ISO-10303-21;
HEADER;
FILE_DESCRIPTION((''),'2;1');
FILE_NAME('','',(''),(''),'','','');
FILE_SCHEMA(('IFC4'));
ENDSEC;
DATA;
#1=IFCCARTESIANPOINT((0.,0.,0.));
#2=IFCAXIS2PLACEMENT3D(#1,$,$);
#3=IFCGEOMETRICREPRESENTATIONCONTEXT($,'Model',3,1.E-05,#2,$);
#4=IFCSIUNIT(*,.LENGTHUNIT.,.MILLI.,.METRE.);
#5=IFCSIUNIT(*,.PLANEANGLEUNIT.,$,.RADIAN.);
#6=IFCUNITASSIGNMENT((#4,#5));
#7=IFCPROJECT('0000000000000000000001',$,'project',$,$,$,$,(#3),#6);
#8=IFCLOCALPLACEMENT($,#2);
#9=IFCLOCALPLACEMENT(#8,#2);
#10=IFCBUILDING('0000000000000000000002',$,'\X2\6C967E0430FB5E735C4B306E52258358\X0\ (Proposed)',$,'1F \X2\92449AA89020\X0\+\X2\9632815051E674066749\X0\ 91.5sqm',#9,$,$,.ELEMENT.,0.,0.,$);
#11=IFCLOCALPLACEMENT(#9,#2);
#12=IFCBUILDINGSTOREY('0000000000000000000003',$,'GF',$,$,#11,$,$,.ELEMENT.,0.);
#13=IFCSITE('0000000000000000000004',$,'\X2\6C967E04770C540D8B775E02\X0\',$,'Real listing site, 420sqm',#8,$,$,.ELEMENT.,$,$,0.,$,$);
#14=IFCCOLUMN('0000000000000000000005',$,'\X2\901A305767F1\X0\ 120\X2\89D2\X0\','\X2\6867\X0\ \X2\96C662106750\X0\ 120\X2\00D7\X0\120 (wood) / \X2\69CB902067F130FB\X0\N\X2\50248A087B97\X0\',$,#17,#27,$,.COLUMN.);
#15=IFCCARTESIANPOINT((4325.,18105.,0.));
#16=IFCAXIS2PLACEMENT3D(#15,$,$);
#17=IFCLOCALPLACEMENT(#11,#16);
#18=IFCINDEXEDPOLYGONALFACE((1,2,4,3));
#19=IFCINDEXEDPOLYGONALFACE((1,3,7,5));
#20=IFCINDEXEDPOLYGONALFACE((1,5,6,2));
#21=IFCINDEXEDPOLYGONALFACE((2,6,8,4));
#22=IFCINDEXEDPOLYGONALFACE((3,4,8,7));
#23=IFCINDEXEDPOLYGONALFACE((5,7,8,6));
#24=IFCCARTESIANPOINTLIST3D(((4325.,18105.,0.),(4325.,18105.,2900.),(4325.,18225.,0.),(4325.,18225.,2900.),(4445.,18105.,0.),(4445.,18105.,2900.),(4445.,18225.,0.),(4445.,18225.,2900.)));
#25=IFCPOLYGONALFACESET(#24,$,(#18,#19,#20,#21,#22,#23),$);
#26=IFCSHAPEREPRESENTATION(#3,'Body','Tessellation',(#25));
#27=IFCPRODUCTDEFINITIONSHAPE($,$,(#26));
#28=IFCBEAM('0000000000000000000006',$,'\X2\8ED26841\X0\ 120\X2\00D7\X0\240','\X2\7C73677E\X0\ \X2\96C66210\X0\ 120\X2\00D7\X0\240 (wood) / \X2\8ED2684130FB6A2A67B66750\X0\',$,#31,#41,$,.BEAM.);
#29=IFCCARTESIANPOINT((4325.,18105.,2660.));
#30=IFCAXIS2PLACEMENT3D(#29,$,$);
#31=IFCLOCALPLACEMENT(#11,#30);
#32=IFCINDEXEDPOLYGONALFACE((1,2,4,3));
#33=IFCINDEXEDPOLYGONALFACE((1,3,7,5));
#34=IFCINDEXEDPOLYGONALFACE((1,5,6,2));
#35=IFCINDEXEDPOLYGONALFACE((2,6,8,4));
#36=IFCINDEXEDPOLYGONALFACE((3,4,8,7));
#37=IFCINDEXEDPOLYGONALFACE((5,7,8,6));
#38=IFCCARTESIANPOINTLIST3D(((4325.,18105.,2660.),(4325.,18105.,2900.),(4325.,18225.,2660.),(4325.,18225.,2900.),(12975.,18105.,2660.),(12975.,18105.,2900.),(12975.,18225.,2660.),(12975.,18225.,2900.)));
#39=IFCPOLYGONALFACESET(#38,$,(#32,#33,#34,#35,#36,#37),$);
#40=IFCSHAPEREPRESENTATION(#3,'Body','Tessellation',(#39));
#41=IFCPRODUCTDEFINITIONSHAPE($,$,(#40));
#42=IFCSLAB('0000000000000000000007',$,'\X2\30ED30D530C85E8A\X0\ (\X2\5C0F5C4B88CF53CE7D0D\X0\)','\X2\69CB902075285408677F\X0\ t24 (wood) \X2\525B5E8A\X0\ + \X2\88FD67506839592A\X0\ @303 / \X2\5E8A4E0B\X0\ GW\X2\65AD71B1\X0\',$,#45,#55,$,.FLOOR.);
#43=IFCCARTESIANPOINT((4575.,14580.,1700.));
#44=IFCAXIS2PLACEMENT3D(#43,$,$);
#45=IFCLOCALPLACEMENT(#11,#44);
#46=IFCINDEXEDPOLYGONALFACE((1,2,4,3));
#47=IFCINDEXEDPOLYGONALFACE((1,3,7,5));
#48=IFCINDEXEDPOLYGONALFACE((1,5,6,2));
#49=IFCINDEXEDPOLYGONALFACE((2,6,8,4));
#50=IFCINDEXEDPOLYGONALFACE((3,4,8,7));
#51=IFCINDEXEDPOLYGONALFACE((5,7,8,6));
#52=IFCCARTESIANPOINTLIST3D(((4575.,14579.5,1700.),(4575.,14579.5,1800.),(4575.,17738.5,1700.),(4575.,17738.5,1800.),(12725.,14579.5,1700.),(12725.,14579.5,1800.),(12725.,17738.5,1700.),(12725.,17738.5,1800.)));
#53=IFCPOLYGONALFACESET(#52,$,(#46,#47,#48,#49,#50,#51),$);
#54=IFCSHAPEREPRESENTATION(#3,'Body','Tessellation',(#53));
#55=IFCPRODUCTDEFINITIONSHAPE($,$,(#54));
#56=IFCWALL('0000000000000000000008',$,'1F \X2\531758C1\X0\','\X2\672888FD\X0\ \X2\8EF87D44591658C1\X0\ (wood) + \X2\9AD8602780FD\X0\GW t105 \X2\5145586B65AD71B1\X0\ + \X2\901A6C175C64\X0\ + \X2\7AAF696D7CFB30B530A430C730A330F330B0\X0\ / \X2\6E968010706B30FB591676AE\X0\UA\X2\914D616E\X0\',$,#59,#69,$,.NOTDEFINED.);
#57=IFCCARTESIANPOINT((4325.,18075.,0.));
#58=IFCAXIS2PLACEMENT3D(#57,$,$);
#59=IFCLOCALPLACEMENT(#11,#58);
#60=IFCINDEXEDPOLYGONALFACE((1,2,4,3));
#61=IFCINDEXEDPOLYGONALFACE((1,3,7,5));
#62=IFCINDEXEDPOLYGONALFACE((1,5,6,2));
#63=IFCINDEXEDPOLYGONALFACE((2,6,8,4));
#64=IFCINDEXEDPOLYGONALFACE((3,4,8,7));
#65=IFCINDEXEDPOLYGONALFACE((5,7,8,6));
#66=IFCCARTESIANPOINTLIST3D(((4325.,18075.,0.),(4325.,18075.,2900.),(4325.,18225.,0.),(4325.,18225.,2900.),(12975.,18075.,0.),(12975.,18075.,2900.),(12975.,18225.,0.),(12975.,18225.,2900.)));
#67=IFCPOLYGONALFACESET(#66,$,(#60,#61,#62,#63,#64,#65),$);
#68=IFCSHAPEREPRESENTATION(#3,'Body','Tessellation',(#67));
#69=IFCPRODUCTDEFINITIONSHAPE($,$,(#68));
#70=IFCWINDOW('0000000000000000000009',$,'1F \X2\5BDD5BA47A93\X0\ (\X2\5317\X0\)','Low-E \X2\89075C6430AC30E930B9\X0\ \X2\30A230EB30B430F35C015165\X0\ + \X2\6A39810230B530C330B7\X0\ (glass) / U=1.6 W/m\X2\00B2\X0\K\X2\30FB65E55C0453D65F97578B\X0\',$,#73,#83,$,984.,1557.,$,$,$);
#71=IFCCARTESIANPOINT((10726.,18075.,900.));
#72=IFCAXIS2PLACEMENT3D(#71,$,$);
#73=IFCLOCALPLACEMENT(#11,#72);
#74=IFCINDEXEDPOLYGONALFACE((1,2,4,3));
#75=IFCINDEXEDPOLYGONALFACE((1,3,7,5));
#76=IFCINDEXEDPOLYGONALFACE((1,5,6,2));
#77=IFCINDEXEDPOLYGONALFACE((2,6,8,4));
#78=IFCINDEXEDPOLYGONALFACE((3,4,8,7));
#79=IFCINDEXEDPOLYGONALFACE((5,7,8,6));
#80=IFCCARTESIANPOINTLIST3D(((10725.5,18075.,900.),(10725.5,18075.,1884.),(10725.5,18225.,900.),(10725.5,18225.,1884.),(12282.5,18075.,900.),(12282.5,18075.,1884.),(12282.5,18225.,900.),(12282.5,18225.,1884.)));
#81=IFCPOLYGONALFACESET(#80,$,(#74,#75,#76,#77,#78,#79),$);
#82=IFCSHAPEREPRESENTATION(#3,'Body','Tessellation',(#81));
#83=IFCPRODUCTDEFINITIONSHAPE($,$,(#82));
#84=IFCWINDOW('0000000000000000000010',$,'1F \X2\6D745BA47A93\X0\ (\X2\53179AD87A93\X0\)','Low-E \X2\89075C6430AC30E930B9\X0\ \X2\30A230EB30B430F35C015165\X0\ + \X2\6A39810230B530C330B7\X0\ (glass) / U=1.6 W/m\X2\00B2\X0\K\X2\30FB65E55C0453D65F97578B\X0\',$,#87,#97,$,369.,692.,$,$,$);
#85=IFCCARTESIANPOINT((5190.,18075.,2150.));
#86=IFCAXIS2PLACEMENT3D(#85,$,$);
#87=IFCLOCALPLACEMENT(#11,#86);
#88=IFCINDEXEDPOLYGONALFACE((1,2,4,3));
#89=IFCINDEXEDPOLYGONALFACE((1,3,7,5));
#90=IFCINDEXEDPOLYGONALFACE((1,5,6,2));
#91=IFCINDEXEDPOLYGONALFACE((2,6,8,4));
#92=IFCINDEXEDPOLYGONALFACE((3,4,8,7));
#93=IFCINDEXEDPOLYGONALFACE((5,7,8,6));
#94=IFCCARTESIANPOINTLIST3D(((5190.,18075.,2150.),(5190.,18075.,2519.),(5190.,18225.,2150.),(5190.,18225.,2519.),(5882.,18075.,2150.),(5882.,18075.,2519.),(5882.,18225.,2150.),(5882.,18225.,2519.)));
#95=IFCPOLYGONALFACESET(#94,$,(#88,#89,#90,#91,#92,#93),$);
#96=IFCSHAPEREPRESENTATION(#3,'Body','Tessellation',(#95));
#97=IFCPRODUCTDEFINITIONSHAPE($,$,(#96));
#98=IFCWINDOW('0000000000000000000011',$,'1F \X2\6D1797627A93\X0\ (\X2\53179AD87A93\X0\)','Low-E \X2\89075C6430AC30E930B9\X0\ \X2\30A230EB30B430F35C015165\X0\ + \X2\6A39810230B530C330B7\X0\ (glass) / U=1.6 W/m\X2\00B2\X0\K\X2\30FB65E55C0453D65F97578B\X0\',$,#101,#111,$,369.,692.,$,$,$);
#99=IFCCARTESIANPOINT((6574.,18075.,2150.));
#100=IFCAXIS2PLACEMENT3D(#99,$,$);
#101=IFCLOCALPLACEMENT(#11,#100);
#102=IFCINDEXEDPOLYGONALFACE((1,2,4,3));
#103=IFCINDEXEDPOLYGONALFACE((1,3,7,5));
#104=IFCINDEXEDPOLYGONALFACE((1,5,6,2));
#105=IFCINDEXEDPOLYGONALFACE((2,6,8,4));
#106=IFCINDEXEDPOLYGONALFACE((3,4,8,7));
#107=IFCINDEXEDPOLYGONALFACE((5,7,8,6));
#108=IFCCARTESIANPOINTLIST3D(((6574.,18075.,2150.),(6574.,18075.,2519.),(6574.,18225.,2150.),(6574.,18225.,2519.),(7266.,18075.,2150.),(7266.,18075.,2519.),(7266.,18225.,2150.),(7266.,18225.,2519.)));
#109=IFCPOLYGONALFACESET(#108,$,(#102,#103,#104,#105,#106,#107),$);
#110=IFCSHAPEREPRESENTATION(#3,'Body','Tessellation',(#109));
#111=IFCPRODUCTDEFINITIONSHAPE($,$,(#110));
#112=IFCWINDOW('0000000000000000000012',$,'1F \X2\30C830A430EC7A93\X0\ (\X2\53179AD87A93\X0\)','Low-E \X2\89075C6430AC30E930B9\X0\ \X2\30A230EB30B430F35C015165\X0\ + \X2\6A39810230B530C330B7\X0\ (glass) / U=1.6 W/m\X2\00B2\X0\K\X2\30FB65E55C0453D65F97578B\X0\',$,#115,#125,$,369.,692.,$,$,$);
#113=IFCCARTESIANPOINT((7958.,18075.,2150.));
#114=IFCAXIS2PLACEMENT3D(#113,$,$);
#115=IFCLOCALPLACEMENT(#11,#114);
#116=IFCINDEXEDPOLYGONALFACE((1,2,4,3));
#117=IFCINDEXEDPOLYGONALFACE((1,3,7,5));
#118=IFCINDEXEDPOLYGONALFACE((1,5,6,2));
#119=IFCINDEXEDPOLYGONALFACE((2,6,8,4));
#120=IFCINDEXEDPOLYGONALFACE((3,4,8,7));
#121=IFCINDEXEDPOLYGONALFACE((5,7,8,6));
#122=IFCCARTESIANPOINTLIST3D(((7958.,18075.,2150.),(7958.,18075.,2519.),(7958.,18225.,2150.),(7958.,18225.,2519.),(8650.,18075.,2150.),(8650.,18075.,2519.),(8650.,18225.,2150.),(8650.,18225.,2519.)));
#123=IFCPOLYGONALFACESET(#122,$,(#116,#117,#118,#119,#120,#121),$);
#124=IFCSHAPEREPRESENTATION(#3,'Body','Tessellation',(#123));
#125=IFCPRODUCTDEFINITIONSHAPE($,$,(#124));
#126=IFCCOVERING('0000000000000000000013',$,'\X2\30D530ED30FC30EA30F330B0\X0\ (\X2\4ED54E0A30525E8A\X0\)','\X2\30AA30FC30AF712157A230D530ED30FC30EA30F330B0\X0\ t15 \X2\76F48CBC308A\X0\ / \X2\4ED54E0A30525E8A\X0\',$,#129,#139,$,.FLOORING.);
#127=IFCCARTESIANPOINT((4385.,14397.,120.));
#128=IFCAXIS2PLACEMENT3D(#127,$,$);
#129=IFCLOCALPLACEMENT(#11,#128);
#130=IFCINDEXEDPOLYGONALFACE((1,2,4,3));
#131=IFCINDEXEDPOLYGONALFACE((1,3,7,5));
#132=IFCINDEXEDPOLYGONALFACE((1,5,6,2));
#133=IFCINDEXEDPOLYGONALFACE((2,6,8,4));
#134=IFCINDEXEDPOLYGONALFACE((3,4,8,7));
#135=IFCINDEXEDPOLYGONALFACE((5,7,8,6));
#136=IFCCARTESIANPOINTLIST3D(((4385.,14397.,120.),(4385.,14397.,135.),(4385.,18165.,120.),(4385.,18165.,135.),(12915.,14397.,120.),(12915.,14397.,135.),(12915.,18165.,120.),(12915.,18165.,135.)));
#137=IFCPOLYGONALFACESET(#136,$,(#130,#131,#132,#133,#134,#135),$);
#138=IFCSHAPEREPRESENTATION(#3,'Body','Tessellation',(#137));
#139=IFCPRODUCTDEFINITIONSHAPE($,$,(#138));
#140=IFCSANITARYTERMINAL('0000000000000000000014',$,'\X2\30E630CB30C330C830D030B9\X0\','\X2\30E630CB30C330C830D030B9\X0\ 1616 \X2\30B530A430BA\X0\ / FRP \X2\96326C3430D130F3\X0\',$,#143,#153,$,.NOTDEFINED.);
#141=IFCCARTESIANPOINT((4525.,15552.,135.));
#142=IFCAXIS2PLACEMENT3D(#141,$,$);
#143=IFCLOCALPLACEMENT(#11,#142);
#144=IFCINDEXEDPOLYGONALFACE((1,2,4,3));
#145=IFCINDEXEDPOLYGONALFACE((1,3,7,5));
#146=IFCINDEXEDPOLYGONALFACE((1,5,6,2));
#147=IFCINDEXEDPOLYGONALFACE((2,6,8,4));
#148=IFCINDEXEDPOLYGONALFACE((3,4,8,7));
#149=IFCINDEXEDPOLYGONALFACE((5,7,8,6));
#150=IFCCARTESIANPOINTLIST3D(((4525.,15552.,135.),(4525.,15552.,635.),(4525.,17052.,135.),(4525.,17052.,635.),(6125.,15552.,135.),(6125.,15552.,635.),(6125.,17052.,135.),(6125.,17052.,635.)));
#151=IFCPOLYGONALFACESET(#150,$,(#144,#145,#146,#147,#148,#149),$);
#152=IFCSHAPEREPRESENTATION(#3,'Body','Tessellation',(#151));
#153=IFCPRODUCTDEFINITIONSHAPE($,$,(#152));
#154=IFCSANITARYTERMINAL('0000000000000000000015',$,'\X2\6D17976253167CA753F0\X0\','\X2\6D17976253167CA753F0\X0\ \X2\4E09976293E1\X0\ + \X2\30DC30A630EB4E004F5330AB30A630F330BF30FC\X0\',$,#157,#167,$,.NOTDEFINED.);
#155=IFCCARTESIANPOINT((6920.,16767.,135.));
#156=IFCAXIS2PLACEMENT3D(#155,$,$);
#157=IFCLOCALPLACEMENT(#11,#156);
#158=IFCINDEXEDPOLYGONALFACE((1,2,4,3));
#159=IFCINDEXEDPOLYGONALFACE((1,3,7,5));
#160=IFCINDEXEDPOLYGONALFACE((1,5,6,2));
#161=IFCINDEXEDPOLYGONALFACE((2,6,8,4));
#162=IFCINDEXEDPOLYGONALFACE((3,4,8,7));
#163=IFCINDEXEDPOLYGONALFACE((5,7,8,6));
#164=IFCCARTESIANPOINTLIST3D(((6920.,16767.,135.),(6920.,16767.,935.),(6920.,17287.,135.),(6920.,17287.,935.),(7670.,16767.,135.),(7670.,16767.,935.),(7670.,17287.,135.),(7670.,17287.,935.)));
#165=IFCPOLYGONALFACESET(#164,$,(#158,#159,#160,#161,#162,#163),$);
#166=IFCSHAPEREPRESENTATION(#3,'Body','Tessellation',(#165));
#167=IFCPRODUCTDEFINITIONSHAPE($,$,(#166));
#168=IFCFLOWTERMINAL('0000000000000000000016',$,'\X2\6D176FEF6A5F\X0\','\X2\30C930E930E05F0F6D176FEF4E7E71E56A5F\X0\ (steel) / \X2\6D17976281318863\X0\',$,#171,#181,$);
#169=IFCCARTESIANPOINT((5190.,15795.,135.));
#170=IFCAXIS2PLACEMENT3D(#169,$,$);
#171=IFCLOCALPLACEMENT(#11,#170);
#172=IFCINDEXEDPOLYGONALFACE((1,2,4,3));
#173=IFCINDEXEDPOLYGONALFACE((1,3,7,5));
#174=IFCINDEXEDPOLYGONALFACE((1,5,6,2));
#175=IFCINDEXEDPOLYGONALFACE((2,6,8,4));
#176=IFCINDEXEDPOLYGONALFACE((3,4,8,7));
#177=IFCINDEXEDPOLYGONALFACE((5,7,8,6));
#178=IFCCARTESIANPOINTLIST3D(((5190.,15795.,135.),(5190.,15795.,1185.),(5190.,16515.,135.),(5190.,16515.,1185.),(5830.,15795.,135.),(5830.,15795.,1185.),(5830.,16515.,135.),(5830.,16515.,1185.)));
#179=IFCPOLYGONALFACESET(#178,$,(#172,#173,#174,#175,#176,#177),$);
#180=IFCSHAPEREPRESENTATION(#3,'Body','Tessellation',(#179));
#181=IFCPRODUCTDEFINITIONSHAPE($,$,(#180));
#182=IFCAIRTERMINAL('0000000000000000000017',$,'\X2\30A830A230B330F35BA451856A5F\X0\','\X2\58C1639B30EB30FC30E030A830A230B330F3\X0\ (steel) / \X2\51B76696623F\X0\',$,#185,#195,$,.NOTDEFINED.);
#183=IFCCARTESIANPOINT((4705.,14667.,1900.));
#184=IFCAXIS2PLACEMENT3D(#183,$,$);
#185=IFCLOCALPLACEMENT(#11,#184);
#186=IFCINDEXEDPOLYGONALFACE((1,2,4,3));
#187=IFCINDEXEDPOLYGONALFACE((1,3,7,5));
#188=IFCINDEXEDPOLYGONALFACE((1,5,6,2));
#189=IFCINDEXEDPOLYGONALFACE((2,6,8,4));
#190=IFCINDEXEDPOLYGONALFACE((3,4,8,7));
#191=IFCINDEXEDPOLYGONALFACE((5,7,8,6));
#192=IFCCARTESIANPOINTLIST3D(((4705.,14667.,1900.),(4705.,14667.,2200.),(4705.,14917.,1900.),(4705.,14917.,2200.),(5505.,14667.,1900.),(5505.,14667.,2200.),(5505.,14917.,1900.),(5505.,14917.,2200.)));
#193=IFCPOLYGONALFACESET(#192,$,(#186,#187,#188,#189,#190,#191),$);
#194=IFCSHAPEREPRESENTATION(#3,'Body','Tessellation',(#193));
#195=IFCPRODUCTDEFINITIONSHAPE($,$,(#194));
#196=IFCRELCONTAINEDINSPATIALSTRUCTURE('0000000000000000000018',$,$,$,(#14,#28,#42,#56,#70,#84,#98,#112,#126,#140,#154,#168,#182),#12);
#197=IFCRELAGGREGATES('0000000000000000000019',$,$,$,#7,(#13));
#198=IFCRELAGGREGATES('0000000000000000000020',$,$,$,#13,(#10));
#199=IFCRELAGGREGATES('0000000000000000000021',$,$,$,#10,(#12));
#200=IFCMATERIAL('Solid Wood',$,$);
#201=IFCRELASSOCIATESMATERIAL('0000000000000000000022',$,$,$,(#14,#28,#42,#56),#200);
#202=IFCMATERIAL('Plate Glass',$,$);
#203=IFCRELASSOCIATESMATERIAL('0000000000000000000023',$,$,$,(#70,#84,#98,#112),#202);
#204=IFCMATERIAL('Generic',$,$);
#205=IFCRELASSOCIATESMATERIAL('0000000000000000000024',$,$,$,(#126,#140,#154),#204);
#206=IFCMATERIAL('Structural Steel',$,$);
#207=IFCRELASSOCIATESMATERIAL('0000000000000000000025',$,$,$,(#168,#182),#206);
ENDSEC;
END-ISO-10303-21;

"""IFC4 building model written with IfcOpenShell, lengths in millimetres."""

from ifc_helpers import new_model, si_unit, frame, frame_2d, origin, place, context, project, spatial, rectangle, extrude, material, element, fill, save


model = new_model("IFC4")

# Units and contexts
model_context = context("Model", 3, precision=1e-05, world=origin())
ifc_project = project(units=[si_unit("LENGTHUNIT", "METRE", prefix="MILLI"), si_unit("PLANEANGLEUNIT", "RADIAN")], contexts=[model_context])

# Site, building, storey
site_placement = place(None, origin())
site = spatial("IfcSite", under=ifc_project, at=site_placement, Name="沖縄県名護市", ObjectType="Real listing site, 420sqm", CompositionType="ELEMENT", RefElevation=0.0)
building_placement = place(site_placement, origin())
building = spatial("IfcBuilding", under=site, at=building_placement, Name="沖縄・平屋の別荘 (Proposed)", ObjectType="1F 鉄骨造+防腐処理杉 91.5sqm", CompositionType="ELEMENT", ElevationOfRefHeight=0.0, ElevationOfTerrain=0.0)
storey_placement = place(building_placement, origin())
storey = spatial("IfcBuildingStorey", under=building, at=storey_placement, Name="GF", CompositionType="ELEMENT", Elevation=0.0)

# Column
ifc_material_1 = material(Name="Solid Wood")
column_1_placement = place(storey_placement, frame((4325.0, 18105.0, 0.0)))
element("IfcColumn", 1, at=column_1_placement, inside=storey, material=ifc_material_1, Name="通し柱 120角", Description="桧 集成材 120×120 (wood) / 構造柱・N値計算", PredefinedType="COLUMN", context=model_context, shape_type="SweptSolid", body=[
    extrude(rectangle(XDim=120.0, YDim=120.0, at=frame_2d((60.0, 60.0))), frame((4325.0, 18105.0, 0.0)), (0.0, 0.0, 1.0), 2900.0),
])

# Beam
beam_1_placement = place(storey_placement, frame((4325.0, 18105.0, 2660.0)))
element("IfcBeam", 2, at=beam_1_placement, inside=storey, material=ifc_material_1, Name="軒桁 120×240", Description="米松 集成 120×240 (wood) / 軒桁・横架材", PredefinedType="BEAM", context=model_context, shape_type="SweptSolid", body=[
    extrude(rectangle(XDim=8650.0, YDim=120.0, at=frame_2d((4325.0, 60.0))), frame((4325.0, 18105.0, 2660.0)), (0.0, 0.0, 1.0), 240.0),
])

# Slab
slab_placement = place(storey_placement, frame((4575.0, 14580.0, 1700.0)))
element("IfcSlab", 3, at=slab_placement, inside=storey, material=ifc_material_1, Name="ロフト床 (小屋裏収納)", Description="構造用合板 t24 (wood) 剛床 + 製材根太 @303 / 床下 GW断熱", PredefinedType="FLOOR", context=model_context, shape_type="SweptSolid", body=[
    extrude(rectangle(XDim=8150.0, YDim=3159.0, at=frame_2d((4075.0, 1579.0))), frame((4575.0, 14580.0, 1700.0)), (0.0, 0.0, 1.0), 100.0),
])

# Wall, openings, windows
wall_1_placement = place(storey_placement, frame((4325.0, 18075.0, 0.0)))
wall_1 = element("IfcWall", 4, at=wall_1_placement, inside=storey, material=ifc_material_1, Name="1F 北壁", Description="木製 軸組外壁 (wood) + 高性能GW t105 充填断熱 + 通気層 + 窯業系サイディング / 準耐火・外皮UA配慮", PredefinedType="NOTDEFINED", context=model_context, shape_type="SweptSolid", body=[
    extrude(rectangle(XDim=8650.0, YDim=150.0, at=frame_2d((4325.0, 75.0))), frame((4325.0, 18075.0, 0.0)), (0.0, 0.0, 1.0), 2900.0),
])
opening_1_placement = place(storey_placement, frame((10726.0, 18075.0, 900.0)))
opening_1 = element("IfcOpeningElement", 5, at=opening_1_placement, cuts=wall_1, PredefinedType="NOTDEFINED", context=model_context, shape_type="SweptSolid", body=[
    extrude(rectangle(XDim=1557.0, YDim=150.0, at=frame_2d((778.0, 75.0))), frame((10726.0, 18075.0, 900.0)), (0.0, 0.0, 1.0), 984.0),
])
opening_2_placement = place(storey_placement, frame((5190.0, 18075.0, 2150.0)))
opening_2 = element("IfcOpeningElement", 6, at=opening_2_placement, cuts=wall_1, PredefinedType="NOTDEFINED", context=model_context, shape_type="SweptSolid", body=[
    extrude(rectangle(XDim=692.0, YDim=150.0, at=frame_2d((346.0, 75.0))), frame((5190.0, 18075.0, 2150.0)), (0.0, 0.0, 1.0), 369.0),
])
opening_3_placement = place(storey_placement, frame((6574.0, 18075.0, 2150.0)))
opening_3 = element("IfcOpeningElement", 7, at=opening_3_placement, cuts=wall_1, PredefinedType="NOTDEFINED", context=model_context, shape_type="SweptSolid", body=[
    extrude(rectangle(XDim=692.0, YDim=150.0, at=frame_2d((346.0, 75.0))), frame((6574.0, 18075.0, 2150.0)), (0.0, 0.0, 1.0), 369.0),
])
opening_4_placement = place(storey_placement, frame((7958.0, 18075.0, 2150.0)))
opening_4 = element("IfcOpeningElement", 8, at=opening_4_placement, cuts=wall_1, PredefinedType="NOTDEFINED", context=model_context, shape_type="SweptSolid", body=[
    extrude(rectangle(XDim=692.0, YDim=150.0, at=frame_2d((346.0, 75.0))), frame((7958.0, 18075.0, 2150.0)), (0.0, 0.0, 1.0), 369.0),
])
ifc_material_2 = material(Name="Plate Glass")
window_1_placement = place(storey_placement, frame((10726.0, 18075.0, 900.0)))
window_1 = element("IfcWindow", 9, at=window_1_placement, inside=storey, material=ifc_material_2, Name="1F 寝室窓 (北)", Description="Low-E 複層ガラス アルゴン封入 + 樹脂サッシ (glass) / U=1.6 W/m²K・日射取得型", OverallHeight=984.0, OverallWidth=1557.0, context=model_context, shape_type="SweptSolid", body=[
    extrude(rectangle(XDim=1557.0, YDim=150.0, at=frame_2d((778.0, 75.0))), frame((10726.0, 18075.0, 900.0)), (0.0, 0.0, 1.0), 984.0),
])
fill(opening_1, window_1)
window_2_placement = place(storey_placement, frame((5190.0, 18075.0, 2150.0)))
window_2 = element("IfcWindow", 10, at=window_2_placement, inside=storey, material=ifc_material_2, Name="1F 浴室窓 (北高窓)", Description="Low-E 複層ガラス アルゴン封入 + 樹脂サッシ (glass) / U=1.6 W/m²K・日射取得型", OverallHeight=369.0, OverallWidth=692.0, context=model_context, shape_type="SweptSolid", body=[
    extrude(rectangle(XDim=692.0, YDim=150.0, at=frame_2d((346.0, 75.0))), frame((5190.0, 18075.0, 2150.0)), (0.0, 0.0, 1.0), 369.0),
])
fill(opening_2, window_2)
window_3_placement = place(storey_placement, frame((6574.0, 18075.0, 2150.0)))
window_3 = element("IfcWindow", 11, at=window_3_placement, inside=storey, material=ifc_material_2, Name="1F 洗面窓 (北高窓)", Description="Low-E 複層ガラス アルゴン封入 + 樹脂サッシ (glass) / U=1.6 W/m²K・日射取得型", OverallHeight=369.0, OverallWidth=692.0, context=model_context, shape_type="SweptSolid", body=[
    extrude(rectangle(XDim=692.0, YDim=150.0, at=frame_2d((346.0, 75.0))), frame((6574.0, 18075.0, 2150.0)), (0.0, 0.0, 1.0), 369.0),
])
fill(opening_3, window_3)
window_4_placement = place(storey_placement, frame((7958.0, 18075.0, 2150.0)))
window_4 = element("IfcWindow", 12, at=window_4_placement, inside=storey, material=ifc_material_2, Name="1F トイレ窓 (北高窓)", Description="Low-E 複層ガラス アルゴン封入 + 樹脂サッシ (glass) / U=1.6 W/m²K・日射取得型", OverallHeight=369.0, OverallWidth=692.0, context=model_context, shape_type="SweptSolid", body=[
    extrude(rectangle(XDim=692.0, YDim=150.0, at=frame_2d((346.0, 75.0))), frame((7958.0, 18075.0, 2150.0)), (0.0, 0.0, 1.0), 369.0),
])
fill(opening_4, window_4)

# Covering
ifc_material_3 = material(Name="Generic")
covering_placement = place(storey_placement, frame((4385.0, 14397.0, 120.0)))
element("IfcCovering", 13, at=covering_placement, inside=storey, material=ifc_material_3, Name="フローリング (仕上げ床)", Description="オーク無垢フローリング t15 直貼り / 仕上げ床", PredefinedType="FLOORING", context=model_context, shape_type="SweptSolid", body=[
    extrude(rectangle(XDim=8530.0, YDim=3768.0, at=frame_2d((4265.0, 1884.0))), frame((4385.0, 14397.0, 120.0)), (0.0, 0.0, 1.0), 15.0),
])

# Sanitary terminals
sanitary_terminal_1_placement = place(storey_placement, frame((4525.0, 15552.0, 135.0)))
element("IfcSanitaryTerminal", 14, at=sanitary_terminal_1_placement, inside=storey, material=ifc_material_3, Name="ユニットバス", Description="ユニットバス 1616 サイズ / FRP 防水パン", PredefinedType="NOTDEFINED", context=model_context, shape_type="SweptSolid", body=[
    extrude(rectangle(XDim=1600.0, YDim=1500.0, at=frame_2d((800.0, 750.0))), frame((4525.0, 15552.0, 135.0)), (0.0, 0.0, 1.0), 500.0),
])
sanitary_terminal_2_placement = place(storey_placement, frame((6920.0, 16767.0, 135.0)))
element("IfcSanitaryTerminal", 15, at=sanitary_terminal_2_placement, inside=storey, material=ifc_material_3, Name="洗面化粧台", Description="洗面化粧台 三面鏡 + ボウル一体カウンター", PredefinedType="NOTDEFINED", context=model_context, shape_type="SweptSolid", body=[
    extrude(rectangle(XDim=750.0, YDim=520.0, at=frame_2d((375.0, 260.0))), frame((6920.0, 16767.0, 135.0)), (0.0, 0.0, 1.0), 800.0),
])

# Flow terminal
ifc_material_4 = material(Name="Structural Steel")
flow_terminal_placement = place(storey_placement, frame((5190.0, 15795.0, 135.0)))
element("IfcFlowTerminal", 16, at=flow_terminal_placement, inside=storey, material=ifc_material_4, Name="洗濯機", Description="ドラム式洗濯乾燥機 (steel) / 洗面脱衣", context=model_context, shape_type="SweptSolid", body=[
    extrude(rectangle(XDim=640.0, YDim=720.0, at=frame_2d((320.0, 360.0))), frame((5190.0, 15795.0, 135.0)), (0.0, 0.0, 1.0), 1050.0),
])

# Air terminal
air_terminal_placement = place(storey_placement, frame((4705.0, 14667.0, 1900.0)))
element("IfcAirTerminal", 17, at=air_terminal_placement, inside=storey, material=ifc_material_4, Name="エアコン室内機", Description="壁掛ルームエアコン (steel) / 冷暖房", PredefinedType="NOTDEFINED", context=model_context, shape_type="SweptSolid", body=[
    extrude(rectangle(XDim=800.0, YDim=250.0, at=frame_2d((400.0, 125.0))), frame((4705.0, 14667.0, 1900.0)), (0.0, 0.0, 1.0), 300.0),
])

save(model, "model.ifc")
